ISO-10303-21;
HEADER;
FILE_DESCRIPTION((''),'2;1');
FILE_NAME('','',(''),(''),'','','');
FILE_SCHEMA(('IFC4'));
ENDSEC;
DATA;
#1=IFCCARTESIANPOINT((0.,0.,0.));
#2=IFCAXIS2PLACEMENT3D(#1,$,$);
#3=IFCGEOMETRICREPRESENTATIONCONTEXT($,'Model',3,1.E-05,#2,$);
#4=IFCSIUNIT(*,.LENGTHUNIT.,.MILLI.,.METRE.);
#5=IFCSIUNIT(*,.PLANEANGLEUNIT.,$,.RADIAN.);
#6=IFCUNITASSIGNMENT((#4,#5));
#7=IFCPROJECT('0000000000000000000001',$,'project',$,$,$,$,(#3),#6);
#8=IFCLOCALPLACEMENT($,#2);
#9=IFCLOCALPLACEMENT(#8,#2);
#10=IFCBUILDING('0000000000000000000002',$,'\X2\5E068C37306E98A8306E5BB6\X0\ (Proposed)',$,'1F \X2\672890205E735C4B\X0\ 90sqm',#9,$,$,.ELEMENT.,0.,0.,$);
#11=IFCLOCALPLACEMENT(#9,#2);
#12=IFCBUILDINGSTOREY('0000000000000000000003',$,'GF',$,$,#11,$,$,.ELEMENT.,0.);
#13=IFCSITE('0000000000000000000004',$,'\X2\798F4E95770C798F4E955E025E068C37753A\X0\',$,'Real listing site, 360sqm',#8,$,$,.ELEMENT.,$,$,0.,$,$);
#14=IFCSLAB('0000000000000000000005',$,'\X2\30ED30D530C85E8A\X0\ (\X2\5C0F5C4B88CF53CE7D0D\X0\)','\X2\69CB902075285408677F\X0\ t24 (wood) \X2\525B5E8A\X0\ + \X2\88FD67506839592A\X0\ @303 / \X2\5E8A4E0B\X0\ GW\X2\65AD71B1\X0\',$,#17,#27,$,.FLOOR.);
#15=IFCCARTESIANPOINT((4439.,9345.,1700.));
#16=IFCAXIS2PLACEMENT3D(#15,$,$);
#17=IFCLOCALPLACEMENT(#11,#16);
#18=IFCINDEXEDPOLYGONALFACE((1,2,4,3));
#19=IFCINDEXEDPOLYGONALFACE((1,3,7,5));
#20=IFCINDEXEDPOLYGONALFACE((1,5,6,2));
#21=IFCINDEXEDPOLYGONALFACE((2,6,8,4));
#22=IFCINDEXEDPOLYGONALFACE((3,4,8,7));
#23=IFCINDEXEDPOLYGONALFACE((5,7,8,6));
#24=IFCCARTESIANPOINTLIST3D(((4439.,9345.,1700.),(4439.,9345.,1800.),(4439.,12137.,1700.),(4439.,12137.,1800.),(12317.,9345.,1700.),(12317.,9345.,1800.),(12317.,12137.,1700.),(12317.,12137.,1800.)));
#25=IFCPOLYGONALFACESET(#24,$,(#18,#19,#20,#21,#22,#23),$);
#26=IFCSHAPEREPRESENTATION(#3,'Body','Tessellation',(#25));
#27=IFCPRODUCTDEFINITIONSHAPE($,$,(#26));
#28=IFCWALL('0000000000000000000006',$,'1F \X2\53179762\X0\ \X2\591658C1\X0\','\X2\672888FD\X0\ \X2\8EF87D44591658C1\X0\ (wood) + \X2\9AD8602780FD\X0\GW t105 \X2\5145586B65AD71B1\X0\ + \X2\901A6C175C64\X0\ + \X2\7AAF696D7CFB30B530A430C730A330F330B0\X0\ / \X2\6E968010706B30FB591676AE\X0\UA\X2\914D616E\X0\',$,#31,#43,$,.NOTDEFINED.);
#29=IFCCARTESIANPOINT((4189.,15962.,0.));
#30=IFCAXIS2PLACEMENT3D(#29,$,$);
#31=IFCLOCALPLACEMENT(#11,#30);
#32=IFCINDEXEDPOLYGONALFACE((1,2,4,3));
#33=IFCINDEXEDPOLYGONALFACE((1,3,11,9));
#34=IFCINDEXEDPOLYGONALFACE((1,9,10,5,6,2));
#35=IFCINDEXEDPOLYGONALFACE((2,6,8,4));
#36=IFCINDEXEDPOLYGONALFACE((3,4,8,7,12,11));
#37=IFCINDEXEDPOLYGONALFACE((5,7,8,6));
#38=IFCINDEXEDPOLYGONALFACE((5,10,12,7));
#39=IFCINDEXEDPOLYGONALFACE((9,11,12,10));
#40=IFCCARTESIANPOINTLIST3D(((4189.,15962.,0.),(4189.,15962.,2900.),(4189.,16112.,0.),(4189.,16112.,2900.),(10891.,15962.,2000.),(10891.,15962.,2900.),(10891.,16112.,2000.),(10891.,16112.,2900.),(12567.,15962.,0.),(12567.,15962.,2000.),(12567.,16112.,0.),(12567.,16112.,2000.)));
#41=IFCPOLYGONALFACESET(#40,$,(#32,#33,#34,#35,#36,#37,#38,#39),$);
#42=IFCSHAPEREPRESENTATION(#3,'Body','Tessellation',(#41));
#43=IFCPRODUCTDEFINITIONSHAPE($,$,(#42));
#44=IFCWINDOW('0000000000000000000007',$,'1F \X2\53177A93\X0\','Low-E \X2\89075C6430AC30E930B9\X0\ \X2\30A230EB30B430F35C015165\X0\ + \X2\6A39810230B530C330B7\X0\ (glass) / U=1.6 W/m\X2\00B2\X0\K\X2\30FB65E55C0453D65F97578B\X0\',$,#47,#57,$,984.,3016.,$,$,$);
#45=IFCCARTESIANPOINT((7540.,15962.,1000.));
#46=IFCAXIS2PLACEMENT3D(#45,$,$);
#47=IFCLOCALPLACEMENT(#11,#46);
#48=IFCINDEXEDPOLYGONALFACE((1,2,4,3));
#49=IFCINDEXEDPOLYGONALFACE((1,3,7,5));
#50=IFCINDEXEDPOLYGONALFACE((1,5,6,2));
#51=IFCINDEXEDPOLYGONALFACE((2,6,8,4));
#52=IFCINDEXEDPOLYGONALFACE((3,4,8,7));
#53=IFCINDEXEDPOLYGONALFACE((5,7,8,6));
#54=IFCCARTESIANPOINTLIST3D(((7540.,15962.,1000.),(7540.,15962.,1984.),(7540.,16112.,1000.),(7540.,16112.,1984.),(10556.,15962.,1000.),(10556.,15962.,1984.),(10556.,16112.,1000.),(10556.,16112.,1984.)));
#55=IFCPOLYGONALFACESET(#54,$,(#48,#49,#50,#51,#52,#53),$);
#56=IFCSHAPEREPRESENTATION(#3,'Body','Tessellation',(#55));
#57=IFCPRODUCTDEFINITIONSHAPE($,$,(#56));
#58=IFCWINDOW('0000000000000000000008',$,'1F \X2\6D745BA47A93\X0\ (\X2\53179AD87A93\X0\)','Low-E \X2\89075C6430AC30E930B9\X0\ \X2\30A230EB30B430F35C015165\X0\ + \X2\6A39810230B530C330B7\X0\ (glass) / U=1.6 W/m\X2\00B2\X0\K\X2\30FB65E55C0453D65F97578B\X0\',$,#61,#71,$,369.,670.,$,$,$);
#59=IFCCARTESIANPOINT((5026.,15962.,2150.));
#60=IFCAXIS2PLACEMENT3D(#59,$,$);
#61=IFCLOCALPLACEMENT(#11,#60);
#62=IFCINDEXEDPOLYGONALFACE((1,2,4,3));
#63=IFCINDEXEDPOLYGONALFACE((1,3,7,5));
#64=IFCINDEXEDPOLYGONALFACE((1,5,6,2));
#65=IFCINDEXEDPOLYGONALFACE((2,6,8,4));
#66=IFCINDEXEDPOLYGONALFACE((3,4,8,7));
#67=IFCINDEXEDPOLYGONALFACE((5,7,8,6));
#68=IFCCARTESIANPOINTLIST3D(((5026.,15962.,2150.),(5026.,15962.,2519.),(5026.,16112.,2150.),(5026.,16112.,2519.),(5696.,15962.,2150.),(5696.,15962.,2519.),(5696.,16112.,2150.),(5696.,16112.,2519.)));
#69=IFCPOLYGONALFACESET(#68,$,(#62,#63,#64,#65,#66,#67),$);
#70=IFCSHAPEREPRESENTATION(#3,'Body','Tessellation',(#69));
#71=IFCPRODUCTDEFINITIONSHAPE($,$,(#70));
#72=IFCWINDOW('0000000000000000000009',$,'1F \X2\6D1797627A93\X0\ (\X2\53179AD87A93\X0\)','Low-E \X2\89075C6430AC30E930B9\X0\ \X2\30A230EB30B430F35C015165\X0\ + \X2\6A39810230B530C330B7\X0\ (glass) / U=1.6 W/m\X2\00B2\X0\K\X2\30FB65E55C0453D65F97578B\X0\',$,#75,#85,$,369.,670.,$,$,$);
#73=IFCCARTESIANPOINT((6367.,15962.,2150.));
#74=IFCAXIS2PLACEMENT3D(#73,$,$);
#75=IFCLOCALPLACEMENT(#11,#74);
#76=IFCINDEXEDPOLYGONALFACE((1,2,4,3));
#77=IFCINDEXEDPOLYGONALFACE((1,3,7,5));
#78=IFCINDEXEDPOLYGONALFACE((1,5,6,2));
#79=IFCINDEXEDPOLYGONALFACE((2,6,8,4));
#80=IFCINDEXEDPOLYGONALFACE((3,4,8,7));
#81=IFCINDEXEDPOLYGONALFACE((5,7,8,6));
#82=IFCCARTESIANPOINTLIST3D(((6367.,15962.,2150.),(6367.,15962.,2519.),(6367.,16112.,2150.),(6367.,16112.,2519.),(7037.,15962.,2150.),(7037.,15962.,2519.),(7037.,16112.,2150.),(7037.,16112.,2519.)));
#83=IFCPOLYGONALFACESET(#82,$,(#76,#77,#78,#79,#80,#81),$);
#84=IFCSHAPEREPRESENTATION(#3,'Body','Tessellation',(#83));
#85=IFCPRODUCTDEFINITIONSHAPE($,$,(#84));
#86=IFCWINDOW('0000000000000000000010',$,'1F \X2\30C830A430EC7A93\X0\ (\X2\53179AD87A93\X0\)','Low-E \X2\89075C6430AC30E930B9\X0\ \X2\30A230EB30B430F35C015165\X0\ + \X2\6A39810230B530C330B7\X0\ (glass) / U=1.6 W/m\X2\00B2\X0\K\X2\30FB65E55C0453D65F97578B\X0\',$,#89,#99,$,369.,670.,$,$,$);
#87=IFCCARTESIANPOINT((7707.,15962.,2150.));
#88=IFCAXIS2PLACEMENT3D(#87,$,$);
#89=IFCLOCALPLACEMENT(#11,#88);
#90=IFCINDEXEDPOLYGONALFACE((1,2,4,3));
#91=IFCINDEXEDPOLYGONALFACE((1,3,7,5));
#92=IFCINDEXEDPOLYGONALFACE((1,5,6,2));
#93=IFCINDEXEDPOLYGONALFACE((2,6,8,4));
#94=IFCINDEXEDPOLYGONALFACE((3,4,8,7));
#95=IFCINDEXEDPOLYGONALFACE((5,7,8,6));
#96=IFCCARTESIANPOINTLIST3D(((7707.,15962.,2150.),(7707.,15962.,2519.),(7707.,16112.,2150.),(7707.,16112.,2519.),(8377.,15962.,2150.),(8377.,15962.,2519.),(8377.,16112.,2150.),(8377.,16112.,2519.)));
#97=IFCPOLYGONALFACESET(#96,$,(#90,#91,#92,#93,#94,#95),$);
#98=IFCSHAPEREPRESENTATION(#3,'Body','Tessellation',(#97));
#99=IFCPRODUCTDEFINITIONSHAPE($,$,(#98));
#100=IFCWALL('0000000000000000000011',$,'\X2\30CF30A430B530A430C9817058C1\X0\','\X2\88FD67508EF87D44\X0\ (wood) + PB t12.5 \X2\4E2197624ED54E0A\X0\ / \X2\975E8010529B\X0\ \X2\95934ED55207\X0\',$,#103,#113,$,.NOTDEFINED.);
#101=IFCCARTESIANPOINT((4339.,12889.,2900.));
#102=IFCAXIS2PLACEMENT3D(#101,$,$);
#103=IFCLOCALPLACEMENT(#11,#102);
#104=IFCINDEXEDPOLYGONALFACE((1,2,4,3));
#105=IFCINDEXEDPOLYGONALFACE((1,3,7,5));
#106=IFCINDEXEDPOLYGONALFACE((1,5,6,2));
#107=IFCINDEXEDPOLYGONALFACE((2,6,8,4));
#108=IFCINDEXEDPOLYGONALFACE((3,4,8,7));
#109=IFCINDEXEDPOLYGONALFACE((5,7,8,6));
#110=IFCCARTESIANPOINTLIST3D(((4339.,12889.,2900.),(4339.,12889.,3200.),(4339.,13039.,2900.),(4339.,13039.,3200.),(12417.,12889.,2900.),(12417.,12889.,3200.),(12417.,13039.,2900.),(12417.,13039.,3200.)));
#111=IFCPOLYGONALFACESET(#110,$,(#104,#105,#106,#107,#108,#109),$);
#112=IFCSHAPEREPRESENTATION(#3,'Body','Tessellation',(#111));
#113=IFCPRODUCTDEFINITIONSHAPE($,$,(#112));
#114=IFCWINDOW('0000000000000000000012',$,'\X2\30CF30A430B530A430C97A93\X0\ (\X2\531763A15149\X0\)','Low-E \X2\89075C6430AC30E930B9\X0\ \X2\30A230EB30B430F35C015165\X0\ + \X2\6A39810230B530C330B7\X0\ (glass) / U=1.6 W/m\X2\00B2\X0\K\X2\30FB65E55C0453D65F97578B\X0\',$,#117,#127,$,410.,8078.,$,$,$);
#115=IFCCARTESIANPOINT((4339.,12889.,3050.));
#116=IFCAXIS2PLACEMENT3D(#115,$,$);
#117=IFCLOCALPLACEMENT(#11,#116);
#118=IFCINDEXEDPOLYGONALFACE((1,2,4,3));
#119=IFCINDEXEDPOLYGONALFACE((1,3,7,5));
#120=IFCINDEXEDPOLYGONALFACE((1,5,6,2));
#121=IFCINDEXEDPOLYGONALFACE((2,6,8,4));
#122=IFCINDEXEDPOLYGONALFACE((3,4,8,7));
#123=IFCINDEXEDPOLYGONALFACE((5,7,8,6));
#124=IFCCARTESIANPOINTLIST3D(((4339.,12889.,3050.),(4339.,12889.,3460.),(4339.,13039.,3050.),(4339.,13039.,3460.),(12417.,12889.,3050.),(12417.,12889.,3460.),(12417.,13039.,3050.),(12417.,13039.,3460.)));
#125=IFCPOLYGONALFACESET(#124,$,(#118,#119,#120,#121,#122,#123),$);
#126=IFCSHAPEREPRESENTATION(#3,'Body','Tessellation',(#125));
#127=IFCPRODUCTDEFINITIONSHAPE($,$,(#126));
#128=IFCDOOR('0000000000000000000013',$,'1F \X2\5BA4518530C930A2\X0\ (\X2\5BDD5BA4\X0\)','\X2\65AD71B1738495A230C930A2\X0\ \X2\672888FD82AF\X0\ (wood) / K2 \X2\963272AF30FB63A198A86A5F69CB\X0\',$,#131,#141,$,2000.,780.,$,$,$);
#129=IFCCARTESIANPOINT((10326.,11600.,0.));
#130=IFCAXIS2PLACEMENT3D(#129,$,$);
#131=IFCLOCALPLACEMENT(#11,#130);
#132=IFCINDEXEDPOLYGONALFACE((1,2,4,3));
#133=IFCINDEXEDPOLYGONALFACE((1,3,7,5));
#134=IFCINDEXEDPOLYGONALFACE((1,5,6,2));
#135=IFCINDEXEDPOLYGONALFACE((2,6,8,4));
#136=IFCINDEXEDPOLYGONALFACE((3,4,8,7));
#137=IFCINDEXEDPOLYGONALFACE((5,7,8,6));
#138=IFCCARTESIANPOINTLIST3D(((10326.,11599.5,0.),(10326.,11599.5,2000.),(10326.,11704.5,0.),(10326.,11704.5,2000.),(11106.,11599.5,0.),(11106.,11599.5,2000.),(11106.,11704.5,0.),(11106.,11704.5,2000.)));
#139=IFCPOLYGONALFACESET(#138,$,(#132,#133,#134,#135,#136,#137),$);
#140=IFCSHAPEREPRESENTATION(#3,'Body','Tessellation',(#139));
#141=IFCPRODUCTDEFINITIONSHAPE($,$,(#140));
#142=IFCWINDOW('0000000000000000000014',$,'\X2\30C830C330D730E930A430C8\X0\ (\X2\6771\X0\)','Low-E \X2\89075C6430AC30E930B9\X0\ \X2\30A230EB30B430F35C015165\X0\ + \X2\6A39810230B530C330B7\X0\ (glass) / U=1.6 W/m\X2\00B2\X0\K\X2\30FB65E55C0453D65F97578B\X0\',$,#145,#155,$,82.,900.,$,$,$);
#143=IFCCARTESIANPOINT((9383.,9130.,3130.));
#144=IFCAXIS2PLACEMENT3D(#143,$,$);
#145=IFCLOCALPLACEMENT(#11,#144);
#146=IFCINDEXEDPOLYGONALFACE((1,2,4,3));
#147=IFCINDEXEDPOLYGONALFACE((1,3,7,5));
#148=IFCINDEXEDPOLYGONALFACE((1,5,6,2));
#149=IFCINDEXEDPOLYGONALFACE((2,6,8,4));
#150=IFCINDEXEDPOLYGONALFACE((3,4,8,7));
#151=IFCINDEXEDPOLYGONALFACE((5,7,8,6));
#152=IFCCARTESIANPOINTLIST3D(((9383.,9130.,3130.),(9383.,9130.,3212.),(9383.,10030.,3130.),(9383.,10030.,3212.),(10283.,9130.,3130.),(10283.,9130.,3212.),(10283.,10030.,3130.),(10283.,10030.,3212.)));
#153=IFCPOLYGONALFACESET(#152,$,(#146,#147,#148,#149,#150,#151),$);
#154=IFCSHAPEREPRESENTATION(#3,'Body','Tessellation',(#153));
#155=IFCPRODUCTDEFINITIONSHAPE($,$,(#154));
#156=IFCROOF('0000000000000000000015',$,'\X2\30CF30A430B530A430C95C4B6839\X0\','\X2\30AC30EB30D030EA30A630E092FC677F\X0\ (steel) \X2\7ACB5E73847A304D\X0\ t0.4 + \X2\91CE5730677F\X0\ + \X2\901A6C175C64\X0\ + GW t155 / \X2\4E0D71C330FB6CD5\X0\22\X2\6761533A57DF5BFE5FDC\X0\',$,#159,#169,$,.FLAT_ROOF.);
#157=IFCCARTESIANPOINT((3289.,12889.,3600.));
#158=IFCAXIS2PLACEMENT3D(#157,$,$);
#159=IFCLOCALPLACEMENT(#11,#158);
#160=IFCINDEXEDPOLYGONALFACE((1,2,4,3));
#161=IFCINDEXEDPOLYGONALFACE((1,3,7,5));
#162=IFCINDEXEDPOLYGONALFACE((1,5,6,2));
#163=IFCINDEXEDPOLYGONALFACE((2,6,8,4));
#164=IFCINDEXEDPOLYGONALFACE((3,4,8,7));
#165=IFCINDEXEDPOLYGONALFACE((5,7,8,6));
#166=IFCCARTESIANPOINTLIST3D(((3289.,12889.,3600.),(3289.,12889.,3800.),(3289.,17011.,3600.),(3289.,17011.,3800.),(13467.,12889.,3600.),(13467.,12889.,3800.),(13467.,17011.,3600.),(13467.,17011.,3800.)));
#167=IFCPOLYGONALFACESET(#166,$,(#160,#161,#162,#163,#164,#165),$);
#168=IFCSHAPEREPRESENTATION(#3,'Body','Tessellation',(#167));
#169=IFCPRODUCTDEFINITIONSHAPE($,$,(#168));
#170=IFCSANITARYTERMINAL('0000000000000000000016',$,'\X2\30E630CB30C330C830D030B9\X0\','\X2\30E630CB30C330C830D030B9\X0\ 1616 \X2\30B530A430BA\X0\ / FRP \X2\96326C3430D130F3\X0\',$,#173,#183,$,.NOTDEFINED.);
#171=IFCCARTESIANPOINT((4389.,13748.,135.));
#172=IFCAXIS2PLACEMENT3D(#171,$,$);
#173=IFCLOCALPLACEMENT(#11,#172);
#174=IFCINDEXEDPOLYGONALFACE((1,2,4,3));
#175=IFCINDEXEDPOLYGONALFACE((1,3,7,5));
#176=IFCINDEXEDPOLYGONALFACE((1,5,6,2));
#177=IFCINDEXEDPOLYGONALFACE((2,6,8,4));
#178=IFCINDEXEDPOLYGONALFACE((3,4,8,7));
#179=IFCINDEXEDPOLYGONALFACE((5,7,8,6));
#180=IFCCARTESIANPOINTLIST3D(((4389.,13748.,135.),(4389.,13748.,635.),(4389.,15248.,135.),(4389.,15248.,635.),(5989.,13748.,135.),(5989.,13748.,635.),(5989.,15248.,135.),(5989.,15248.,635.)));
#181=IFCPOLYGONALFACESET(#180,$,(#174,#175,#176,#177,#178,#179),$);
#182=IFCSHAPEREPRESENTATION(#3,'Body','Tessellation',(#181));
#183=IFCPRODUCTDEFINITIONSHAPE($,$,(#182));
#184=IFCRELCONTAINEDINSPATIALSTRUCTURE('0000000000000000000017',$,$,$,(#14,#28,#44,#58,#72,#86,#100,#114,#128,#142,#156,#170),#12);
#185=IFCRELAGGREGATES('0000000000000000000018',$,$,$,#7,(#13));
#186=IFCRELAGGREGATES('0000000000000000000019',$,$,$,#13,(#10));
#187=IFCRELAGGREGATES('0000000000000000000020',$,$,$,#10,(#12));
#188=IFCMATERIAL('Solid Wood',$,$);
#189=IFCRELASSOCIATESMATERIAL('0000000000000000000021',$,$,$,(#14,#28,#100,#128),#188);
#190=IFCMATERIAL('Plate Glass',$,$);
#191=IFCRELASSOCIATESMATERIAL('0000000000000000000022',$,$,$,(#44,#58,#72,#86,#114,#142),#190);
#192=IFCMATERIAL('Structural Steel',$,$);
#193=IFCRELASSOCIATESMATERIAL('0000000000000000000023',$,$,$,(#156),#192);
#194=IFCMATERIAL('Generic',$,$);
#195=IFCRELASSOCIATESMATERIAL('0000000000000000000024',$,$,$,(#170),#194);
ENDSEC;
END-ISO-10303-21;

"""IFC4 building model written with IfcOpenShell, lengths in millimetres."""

from ifc_helpers import new_model, si_unit, frame, frame_2d, origin, place, context, project, spatial, rectangle, extrude, material, element, fill, save


model = new_model("IFC4")

# Units and contexts
model_context = context("Model", 3, precision=1e-05, world=origin())
ifc_project = project(units=[si_unit("LENGTHUNIT", "METRE", prefix="MILLI"), si_unit("PLANEANGLEUNIT", "RADIAN")], contexts=[model_context])

# Site, building, storey
site_placement = place(None, origin())
site = spatial("IfcSite", under=ifc_project, at=site_placement, Name="福井県福井市帆谷町", ObjectType="Real listing site, 360sqm", CompositionType="ELEMENT", RefElevation=0.0)
building_placement = place(site_placement, origin())
building = spatial("IfcBuilding", under=site, at=building_placement, Name="帆谷の風の家 (Proposed)", ObjectType="1F 木造平屋 90sqm", CompositionType="ELEMENT", ElevationOfRefHeight=0.0, ElevationOfTerrain=0.0)
storey_placement = place(building_placement, origin())
storey = spatial("IfcBuildingStorey", under=building, at=storey_placement, Name="GF", CompositionType="ELEMENT", Elevation=0.0)

# Slab
ifc_material_1 = material(Name="Solid Wood")
slab_placement = place(storey_placement, frame((4439.0, 9345.0, 1700.0)))
element("IfcSlab", 1, at=slab_placement, inside=storey, material=ifc_material_1, Name="ロフト床 (小屋裏収納)", Description="構造用合板 t24 (wood) 剛床 + 製材根太 @303 / 床下 GW断熱", PredefinedType="FLOOR", context=model_context, shape_type="SweptSolid", body=[
    extrude(rectangle(XDim=7878.0, YDim=2792.0, at=frame_2d((3939.0, 1396.0))), frame((4439.0, 9345.0, 1700.0)), (0.0, 0.0, 1.0), 100.0),
])

# Wall, openings, windows
wall_1_placement = place(storey_placement, frame((4189.0, 15962.0, 0.0)))
wall_1 = element("IfcWall", 2, at=wall_1_placement, inside=storey, material=ifc_material_1, Name="1F 北面 外壁", Description="木製 軸組外壁 (wood) + 高性能GW t105 充填断熱 + 通気層 + 窯業系サイディング / 準耐火・外皮UA配慮", PredefinedType="NOTDEFINED", context=model_context, shape_type="SweptSolid", body=[
    extrude(rectangle(XDim=8378.0, YDim=150.0, at=frame_2d((4189.0, 75.0))), frame((4189.0, 15962.0, 0.0)), (0.0, 0.0, 1.0), 2900.0),
])
opening_1_placement = place(storey_placement, frame((7540.0, 15962.0, 1000.0)))
opening_1 = element("IfcOpeningElement", 3, at=opening_1_placement, cuts=wall_1, PredefinedType="NOTDEFINED", context=model_context, shape_type="SweptSolid", body=[
    extrude(rectangle(XDim=3016.0, YDim=150.0, at=frame_2d((1508.0, 75.0))), frame((7540.0, 15962.0, 1000.0)), (0.0, 0.0, 1.0), 984.0),
])
opening_2_placement = place(storey_placement, frame((5026.0, 15962.0, 2150.0)))
opening_2 = element("IfcOpeningElement", 4, at=opening_2_placement, cuts=wall_1, PredefinedType="NOTDEFINED", context=model_context, shape_type="SweptSolid", body=[
    extrude(rectangle(XDim=670.0, YDim=150.0, at=frame_2d((335.0, 75.0))), frame((5026.0, 15962.0, 2150.0)), (0.0, 0.0, 1.0), 369.0),
])
opening_3_placement = place(storey_placement, frame((6367.0, 15962.0, 2150.0)))
opening_3 = element("IfcOpeningElement", 5, at=opening_3_placement, cuts=wall_1, PredefinedType="NOTDEFINED", context=model_context, shape_type="SweptSolid", body=[
    extrude(rectangle(XDim=670.0, YDim=150.0, at=frame_2d((335.0, 75.0))), frame((6367.0, 15962.0, 2150.0)), (0.0, 0.0, 1.0), 369.0),
])
opening_4_placement = place(storey_placement, frame((7707.0, 15962.0, 2150.0)))
opening_4 = element("IfcOpeningElement", 6, at=opening_4_placement, cuts=wall_1, PredefinedType="NOTDEFINED", context=model_context, shape_type="SweptSolid", body=[
    extrude(rectangle(XDim=670.0, YDim=150.0, at=frame_2d((335.0, 75.0))), frame((7707.0, 15962.0, 2150.0)), (0.0, 0.0, 1.0), 369.0),
])
ifc_material_2 = material(Name="Plate Glass")
window_1_placement = place(storey_placement, frame((7540.0, 15962.0, 1000.0)))
window_1 = element("IfcWindow", 7, at=window_1_placement, inside=storey, material=ifc_material_2, Name="1F 北窓", Description="Low-E 複層ガラス アルゴン封入 + 樹脂サッシ (glass) / U=1.6 W/m²K・日射取得型", OverallHeight=984.0, OverallWidth=3016.0, context=model_context, shape_type="SweptSolid", body=[
    extrude(rectangle(XDim=3016.0, YDim=150.0, at=frame_2d((1508.0, 75.0))), frame((7540.0, 15962.0, 1000.0)), (0.0, 0.0, 1.0), 984.0),
])
fill(opening_1, window_1)
window_2_placement = place(storey_placement, frame((5026.0, 15962.0, 2150.0)))
window_2 = element("IfcWindow", 8, at=window_2_placement, inside=storey, material=ifc_material_2, Name="1F 浴室窓 (北高窓)", Description="Low-E 複層ガラス アルゴン封入 + 樹脂サッシ (glass) / U=1.6 W/m²K・日射取得型", OverallHeight=369.0, OverallWidth=670.0, context=model_context, shape_type="SweptSolid", body=[
    extrude(rectangle(XDim=670.0, YDim=150.0, at=frame_2d((335.0, 75.0))), frame((5026.0, 15962.0, 2150.0)), (0.0, 0.0, 1.0), 369.0),
])
fill(opening_2, window_2)
window_3_placement = place(storey_placement, frame((6367.0, 15962.0, 2150.0)))
window_3 = element("IfcWindow", 9, at=window_3_placement, inside=storey, material=ifc_material_2, Name="1F 洗面窓 (北高窓)", Description="Low-E 複層ガラス アルゴン封入 + 樹脂サッシ (glass) / U=1.6 W/m²K・日射取得型", OverallHeight=369.0, OverallWidth=670.0, context=model_context, shape_type="SweptSolid", body=[
    extrude(rectangle(XDim=670.0, YDim=150.0, at=frame_2d((335.0, 75.0))), frame((6367.0, 15962.0, 2150.0)), (0.0, 0.0, 1.0), 369.0),
])
fill(opening_3, window_3)
window_4_placement = place(storey_placement, frame((7707.0, 15962.0, 2150.0)))
window_4 = element("IfcWindow", 10, at=window_4_placement, inside=storey, material=ifc_material_2, Name="1F トイレ窓 (北高窓)", Description="Low-E 複層ガラス アルゴン封入 + 樹脂サッシ (glass) / U=1.6 W/m²K・日射取得型", OverallHeight=369.0, OverallWidth=670.0, context=model_context, shape_type="SweptSolid", body=[
    extrude(rectangle(XDim=670.0, YDim=150.0, at=frame_2d((335.0, 75.0))), frame((7707.0, 15962.0, 2150.0)), (0.0, 0.0, 1.0), 369.0),
])
fill(opening_4, window_4)

# Wall, opening, window
wall_2_placement = place(storey_placement, frame((4339.0, 12889.0, 2900.0)))
wall_2 = element("IfcWall", 11, at=wall_2_placement, inside=storey, material=ifc_material_1, Name="ハイサイド腰壁", Description="製材軸組 (wood) + PB t12.5 両面仕上 / 非耐力 間仕切", PredefinedType="NOTDEFINED", context=model_context, shape_type="SweptSolid", body=[
    extrude(rectangle(XDim=8078.0, YDim=150.0, at=frame_2d((4039.0, 75.0))), frame((4339.0, 12889.0, 2900.0)), (0.0, 0.0, 1.0), 700.0),
])
opening_5_placement = place(storey_placement, frame((4339.0, 12889.0, 3050.0)))
opening_5 = element("IfcOpeningElement", 12, at=opening_5_placement, cuts=wall_2, PredefinedType="NOTDEFINED", context=model_context, shape_type="SweptSolid", body=[
    extrude(rectangle(XDim=8078.0, YDim=150.0, at=frame_2d((4039.0, 75.0))), frame((4339.0, 12889.0, 3050.0)), (0.0, 0.0, 1.0), 410.0),
])
window_5_placement = place(storey_placement, frame((4339.0, 12889.0, 3050.0)))
window_5 = element("IfcWindow", 13, at=window_5_placement, inside=storey, material=ifc_material_2, Name="ハイサイド窓 (北採光)", Description="Low-E 複層ガラス アルゴン封入 + 樹脂サッシ (glass) / U=1.6 W/m²K・日射取得型", OverallHeight=410.0, OverallWidth=8078.0, context=model_context, shape_type="SweptSolid", body=[
    extrude(rectangle(XDim=8078.0, YDim=150.0, at=frame_2d((4039.0, 75.0))), frame((4339.0, 12889.0, 3050.0)), (0.0, 0.0, 1.0), 410.0),
])
fill(opening_5, window_5)

# Door
door_1_placement = place(storey_placement, frame((10326.0, 11600.0, 0.0)))
element("IfcDoor", 14, at=door_1_placement, inside=storey, material=ifc_material_1, Name="1F 室内ドア (寝室)", Description="断熱玄関ドア 木製芯 (wood) / K2 防犯・採風機構", OverallHeight=2000.0, OverallWidth=780.0, context=model_context, shape_type="SweptSolid", body=[
    extrude(rectangle(XDim=780.0, YDim=105.0, at=frame_2d((390.0, 52.0))), frame((10326.0, 11600.0, 0.0)), (0.0, 0.0, 1.0), 2000.0),
])

# Window
window_6_placement = place(storey_placement, frame((9383.0, 9130.0, 3130.0)))
element("IfcWindow", 15, at=window_6_placement, inside=storey, material=ifc_material_2, Name="トップライト (東)", Description="Low-E 複層ガラス アルゴン封入 + 樹脂サッシ (glass) / U=1.6 W/m²K・日射取得型", OverallHeight=82.0, OverallWidth=900.0, context=model_context, shape_type="SweptSolid", body=[
    extrude(rectangle(XDim=900.0, YDim=900.0, at=frame_2d((450.0, 450.0))), frame((9383.0, 9130.0, 3130.0)), (0.0, 0.0, 1.0), 82.0),
])

# Roof
ifc_material_3 = material(Name="Structural Steel")
roof_placement = place(storey_placement, frame((3289.0, 12889.0, 3600.0)))
element("IfcRoof", 16, at=roof_placement, inside=storey, material=ifc_material_3, Name="ハイサイド屋根", Description="ガルバリウム鋼板 (steel) 立平葺き t0.4 + 野地板 + 通気層 + GW t155 / 不燃・法22条区域対応", PredefinedType="FLAT_ROOF", context=model_context, shape_type="SweptSolid", body=[
    extrude(rectangle(XDim=10178.0, YDim=4122.0, at=frame_2d((5089.0, 2061.0))), frame((3289.0, 12889.0, 3600.0)), (0.0, 0.0, 1.0), 200.0),
])

# Sanitary terminal
ifc_material_4 = material(Name="Generic")
sanitary_terminal_1_placement = place(storey_placement, frame((4389.0, 13748.0, 135.0)))
element("IfcSanitaryTerminal", 17, at=sanitary_terminal_1_placement, inside=storey, material=ifc_material_4, Name="ユニットバス", Description="ユニットバス 1616 サイズ / FRP 防水パン", PredefinedType="NOTDEFINED", context=model_context, shape_type="SweptSolid", body=[
    extrude(rectangle(XDim=1600.0, YDim=1500.0, at=frame_2d((800.0, 750.0))), frame((4389.0, 13748.0, 135.0)), (0.0, 0.0, 1.0), 500.0),
])

save(model, "model.ifc")
